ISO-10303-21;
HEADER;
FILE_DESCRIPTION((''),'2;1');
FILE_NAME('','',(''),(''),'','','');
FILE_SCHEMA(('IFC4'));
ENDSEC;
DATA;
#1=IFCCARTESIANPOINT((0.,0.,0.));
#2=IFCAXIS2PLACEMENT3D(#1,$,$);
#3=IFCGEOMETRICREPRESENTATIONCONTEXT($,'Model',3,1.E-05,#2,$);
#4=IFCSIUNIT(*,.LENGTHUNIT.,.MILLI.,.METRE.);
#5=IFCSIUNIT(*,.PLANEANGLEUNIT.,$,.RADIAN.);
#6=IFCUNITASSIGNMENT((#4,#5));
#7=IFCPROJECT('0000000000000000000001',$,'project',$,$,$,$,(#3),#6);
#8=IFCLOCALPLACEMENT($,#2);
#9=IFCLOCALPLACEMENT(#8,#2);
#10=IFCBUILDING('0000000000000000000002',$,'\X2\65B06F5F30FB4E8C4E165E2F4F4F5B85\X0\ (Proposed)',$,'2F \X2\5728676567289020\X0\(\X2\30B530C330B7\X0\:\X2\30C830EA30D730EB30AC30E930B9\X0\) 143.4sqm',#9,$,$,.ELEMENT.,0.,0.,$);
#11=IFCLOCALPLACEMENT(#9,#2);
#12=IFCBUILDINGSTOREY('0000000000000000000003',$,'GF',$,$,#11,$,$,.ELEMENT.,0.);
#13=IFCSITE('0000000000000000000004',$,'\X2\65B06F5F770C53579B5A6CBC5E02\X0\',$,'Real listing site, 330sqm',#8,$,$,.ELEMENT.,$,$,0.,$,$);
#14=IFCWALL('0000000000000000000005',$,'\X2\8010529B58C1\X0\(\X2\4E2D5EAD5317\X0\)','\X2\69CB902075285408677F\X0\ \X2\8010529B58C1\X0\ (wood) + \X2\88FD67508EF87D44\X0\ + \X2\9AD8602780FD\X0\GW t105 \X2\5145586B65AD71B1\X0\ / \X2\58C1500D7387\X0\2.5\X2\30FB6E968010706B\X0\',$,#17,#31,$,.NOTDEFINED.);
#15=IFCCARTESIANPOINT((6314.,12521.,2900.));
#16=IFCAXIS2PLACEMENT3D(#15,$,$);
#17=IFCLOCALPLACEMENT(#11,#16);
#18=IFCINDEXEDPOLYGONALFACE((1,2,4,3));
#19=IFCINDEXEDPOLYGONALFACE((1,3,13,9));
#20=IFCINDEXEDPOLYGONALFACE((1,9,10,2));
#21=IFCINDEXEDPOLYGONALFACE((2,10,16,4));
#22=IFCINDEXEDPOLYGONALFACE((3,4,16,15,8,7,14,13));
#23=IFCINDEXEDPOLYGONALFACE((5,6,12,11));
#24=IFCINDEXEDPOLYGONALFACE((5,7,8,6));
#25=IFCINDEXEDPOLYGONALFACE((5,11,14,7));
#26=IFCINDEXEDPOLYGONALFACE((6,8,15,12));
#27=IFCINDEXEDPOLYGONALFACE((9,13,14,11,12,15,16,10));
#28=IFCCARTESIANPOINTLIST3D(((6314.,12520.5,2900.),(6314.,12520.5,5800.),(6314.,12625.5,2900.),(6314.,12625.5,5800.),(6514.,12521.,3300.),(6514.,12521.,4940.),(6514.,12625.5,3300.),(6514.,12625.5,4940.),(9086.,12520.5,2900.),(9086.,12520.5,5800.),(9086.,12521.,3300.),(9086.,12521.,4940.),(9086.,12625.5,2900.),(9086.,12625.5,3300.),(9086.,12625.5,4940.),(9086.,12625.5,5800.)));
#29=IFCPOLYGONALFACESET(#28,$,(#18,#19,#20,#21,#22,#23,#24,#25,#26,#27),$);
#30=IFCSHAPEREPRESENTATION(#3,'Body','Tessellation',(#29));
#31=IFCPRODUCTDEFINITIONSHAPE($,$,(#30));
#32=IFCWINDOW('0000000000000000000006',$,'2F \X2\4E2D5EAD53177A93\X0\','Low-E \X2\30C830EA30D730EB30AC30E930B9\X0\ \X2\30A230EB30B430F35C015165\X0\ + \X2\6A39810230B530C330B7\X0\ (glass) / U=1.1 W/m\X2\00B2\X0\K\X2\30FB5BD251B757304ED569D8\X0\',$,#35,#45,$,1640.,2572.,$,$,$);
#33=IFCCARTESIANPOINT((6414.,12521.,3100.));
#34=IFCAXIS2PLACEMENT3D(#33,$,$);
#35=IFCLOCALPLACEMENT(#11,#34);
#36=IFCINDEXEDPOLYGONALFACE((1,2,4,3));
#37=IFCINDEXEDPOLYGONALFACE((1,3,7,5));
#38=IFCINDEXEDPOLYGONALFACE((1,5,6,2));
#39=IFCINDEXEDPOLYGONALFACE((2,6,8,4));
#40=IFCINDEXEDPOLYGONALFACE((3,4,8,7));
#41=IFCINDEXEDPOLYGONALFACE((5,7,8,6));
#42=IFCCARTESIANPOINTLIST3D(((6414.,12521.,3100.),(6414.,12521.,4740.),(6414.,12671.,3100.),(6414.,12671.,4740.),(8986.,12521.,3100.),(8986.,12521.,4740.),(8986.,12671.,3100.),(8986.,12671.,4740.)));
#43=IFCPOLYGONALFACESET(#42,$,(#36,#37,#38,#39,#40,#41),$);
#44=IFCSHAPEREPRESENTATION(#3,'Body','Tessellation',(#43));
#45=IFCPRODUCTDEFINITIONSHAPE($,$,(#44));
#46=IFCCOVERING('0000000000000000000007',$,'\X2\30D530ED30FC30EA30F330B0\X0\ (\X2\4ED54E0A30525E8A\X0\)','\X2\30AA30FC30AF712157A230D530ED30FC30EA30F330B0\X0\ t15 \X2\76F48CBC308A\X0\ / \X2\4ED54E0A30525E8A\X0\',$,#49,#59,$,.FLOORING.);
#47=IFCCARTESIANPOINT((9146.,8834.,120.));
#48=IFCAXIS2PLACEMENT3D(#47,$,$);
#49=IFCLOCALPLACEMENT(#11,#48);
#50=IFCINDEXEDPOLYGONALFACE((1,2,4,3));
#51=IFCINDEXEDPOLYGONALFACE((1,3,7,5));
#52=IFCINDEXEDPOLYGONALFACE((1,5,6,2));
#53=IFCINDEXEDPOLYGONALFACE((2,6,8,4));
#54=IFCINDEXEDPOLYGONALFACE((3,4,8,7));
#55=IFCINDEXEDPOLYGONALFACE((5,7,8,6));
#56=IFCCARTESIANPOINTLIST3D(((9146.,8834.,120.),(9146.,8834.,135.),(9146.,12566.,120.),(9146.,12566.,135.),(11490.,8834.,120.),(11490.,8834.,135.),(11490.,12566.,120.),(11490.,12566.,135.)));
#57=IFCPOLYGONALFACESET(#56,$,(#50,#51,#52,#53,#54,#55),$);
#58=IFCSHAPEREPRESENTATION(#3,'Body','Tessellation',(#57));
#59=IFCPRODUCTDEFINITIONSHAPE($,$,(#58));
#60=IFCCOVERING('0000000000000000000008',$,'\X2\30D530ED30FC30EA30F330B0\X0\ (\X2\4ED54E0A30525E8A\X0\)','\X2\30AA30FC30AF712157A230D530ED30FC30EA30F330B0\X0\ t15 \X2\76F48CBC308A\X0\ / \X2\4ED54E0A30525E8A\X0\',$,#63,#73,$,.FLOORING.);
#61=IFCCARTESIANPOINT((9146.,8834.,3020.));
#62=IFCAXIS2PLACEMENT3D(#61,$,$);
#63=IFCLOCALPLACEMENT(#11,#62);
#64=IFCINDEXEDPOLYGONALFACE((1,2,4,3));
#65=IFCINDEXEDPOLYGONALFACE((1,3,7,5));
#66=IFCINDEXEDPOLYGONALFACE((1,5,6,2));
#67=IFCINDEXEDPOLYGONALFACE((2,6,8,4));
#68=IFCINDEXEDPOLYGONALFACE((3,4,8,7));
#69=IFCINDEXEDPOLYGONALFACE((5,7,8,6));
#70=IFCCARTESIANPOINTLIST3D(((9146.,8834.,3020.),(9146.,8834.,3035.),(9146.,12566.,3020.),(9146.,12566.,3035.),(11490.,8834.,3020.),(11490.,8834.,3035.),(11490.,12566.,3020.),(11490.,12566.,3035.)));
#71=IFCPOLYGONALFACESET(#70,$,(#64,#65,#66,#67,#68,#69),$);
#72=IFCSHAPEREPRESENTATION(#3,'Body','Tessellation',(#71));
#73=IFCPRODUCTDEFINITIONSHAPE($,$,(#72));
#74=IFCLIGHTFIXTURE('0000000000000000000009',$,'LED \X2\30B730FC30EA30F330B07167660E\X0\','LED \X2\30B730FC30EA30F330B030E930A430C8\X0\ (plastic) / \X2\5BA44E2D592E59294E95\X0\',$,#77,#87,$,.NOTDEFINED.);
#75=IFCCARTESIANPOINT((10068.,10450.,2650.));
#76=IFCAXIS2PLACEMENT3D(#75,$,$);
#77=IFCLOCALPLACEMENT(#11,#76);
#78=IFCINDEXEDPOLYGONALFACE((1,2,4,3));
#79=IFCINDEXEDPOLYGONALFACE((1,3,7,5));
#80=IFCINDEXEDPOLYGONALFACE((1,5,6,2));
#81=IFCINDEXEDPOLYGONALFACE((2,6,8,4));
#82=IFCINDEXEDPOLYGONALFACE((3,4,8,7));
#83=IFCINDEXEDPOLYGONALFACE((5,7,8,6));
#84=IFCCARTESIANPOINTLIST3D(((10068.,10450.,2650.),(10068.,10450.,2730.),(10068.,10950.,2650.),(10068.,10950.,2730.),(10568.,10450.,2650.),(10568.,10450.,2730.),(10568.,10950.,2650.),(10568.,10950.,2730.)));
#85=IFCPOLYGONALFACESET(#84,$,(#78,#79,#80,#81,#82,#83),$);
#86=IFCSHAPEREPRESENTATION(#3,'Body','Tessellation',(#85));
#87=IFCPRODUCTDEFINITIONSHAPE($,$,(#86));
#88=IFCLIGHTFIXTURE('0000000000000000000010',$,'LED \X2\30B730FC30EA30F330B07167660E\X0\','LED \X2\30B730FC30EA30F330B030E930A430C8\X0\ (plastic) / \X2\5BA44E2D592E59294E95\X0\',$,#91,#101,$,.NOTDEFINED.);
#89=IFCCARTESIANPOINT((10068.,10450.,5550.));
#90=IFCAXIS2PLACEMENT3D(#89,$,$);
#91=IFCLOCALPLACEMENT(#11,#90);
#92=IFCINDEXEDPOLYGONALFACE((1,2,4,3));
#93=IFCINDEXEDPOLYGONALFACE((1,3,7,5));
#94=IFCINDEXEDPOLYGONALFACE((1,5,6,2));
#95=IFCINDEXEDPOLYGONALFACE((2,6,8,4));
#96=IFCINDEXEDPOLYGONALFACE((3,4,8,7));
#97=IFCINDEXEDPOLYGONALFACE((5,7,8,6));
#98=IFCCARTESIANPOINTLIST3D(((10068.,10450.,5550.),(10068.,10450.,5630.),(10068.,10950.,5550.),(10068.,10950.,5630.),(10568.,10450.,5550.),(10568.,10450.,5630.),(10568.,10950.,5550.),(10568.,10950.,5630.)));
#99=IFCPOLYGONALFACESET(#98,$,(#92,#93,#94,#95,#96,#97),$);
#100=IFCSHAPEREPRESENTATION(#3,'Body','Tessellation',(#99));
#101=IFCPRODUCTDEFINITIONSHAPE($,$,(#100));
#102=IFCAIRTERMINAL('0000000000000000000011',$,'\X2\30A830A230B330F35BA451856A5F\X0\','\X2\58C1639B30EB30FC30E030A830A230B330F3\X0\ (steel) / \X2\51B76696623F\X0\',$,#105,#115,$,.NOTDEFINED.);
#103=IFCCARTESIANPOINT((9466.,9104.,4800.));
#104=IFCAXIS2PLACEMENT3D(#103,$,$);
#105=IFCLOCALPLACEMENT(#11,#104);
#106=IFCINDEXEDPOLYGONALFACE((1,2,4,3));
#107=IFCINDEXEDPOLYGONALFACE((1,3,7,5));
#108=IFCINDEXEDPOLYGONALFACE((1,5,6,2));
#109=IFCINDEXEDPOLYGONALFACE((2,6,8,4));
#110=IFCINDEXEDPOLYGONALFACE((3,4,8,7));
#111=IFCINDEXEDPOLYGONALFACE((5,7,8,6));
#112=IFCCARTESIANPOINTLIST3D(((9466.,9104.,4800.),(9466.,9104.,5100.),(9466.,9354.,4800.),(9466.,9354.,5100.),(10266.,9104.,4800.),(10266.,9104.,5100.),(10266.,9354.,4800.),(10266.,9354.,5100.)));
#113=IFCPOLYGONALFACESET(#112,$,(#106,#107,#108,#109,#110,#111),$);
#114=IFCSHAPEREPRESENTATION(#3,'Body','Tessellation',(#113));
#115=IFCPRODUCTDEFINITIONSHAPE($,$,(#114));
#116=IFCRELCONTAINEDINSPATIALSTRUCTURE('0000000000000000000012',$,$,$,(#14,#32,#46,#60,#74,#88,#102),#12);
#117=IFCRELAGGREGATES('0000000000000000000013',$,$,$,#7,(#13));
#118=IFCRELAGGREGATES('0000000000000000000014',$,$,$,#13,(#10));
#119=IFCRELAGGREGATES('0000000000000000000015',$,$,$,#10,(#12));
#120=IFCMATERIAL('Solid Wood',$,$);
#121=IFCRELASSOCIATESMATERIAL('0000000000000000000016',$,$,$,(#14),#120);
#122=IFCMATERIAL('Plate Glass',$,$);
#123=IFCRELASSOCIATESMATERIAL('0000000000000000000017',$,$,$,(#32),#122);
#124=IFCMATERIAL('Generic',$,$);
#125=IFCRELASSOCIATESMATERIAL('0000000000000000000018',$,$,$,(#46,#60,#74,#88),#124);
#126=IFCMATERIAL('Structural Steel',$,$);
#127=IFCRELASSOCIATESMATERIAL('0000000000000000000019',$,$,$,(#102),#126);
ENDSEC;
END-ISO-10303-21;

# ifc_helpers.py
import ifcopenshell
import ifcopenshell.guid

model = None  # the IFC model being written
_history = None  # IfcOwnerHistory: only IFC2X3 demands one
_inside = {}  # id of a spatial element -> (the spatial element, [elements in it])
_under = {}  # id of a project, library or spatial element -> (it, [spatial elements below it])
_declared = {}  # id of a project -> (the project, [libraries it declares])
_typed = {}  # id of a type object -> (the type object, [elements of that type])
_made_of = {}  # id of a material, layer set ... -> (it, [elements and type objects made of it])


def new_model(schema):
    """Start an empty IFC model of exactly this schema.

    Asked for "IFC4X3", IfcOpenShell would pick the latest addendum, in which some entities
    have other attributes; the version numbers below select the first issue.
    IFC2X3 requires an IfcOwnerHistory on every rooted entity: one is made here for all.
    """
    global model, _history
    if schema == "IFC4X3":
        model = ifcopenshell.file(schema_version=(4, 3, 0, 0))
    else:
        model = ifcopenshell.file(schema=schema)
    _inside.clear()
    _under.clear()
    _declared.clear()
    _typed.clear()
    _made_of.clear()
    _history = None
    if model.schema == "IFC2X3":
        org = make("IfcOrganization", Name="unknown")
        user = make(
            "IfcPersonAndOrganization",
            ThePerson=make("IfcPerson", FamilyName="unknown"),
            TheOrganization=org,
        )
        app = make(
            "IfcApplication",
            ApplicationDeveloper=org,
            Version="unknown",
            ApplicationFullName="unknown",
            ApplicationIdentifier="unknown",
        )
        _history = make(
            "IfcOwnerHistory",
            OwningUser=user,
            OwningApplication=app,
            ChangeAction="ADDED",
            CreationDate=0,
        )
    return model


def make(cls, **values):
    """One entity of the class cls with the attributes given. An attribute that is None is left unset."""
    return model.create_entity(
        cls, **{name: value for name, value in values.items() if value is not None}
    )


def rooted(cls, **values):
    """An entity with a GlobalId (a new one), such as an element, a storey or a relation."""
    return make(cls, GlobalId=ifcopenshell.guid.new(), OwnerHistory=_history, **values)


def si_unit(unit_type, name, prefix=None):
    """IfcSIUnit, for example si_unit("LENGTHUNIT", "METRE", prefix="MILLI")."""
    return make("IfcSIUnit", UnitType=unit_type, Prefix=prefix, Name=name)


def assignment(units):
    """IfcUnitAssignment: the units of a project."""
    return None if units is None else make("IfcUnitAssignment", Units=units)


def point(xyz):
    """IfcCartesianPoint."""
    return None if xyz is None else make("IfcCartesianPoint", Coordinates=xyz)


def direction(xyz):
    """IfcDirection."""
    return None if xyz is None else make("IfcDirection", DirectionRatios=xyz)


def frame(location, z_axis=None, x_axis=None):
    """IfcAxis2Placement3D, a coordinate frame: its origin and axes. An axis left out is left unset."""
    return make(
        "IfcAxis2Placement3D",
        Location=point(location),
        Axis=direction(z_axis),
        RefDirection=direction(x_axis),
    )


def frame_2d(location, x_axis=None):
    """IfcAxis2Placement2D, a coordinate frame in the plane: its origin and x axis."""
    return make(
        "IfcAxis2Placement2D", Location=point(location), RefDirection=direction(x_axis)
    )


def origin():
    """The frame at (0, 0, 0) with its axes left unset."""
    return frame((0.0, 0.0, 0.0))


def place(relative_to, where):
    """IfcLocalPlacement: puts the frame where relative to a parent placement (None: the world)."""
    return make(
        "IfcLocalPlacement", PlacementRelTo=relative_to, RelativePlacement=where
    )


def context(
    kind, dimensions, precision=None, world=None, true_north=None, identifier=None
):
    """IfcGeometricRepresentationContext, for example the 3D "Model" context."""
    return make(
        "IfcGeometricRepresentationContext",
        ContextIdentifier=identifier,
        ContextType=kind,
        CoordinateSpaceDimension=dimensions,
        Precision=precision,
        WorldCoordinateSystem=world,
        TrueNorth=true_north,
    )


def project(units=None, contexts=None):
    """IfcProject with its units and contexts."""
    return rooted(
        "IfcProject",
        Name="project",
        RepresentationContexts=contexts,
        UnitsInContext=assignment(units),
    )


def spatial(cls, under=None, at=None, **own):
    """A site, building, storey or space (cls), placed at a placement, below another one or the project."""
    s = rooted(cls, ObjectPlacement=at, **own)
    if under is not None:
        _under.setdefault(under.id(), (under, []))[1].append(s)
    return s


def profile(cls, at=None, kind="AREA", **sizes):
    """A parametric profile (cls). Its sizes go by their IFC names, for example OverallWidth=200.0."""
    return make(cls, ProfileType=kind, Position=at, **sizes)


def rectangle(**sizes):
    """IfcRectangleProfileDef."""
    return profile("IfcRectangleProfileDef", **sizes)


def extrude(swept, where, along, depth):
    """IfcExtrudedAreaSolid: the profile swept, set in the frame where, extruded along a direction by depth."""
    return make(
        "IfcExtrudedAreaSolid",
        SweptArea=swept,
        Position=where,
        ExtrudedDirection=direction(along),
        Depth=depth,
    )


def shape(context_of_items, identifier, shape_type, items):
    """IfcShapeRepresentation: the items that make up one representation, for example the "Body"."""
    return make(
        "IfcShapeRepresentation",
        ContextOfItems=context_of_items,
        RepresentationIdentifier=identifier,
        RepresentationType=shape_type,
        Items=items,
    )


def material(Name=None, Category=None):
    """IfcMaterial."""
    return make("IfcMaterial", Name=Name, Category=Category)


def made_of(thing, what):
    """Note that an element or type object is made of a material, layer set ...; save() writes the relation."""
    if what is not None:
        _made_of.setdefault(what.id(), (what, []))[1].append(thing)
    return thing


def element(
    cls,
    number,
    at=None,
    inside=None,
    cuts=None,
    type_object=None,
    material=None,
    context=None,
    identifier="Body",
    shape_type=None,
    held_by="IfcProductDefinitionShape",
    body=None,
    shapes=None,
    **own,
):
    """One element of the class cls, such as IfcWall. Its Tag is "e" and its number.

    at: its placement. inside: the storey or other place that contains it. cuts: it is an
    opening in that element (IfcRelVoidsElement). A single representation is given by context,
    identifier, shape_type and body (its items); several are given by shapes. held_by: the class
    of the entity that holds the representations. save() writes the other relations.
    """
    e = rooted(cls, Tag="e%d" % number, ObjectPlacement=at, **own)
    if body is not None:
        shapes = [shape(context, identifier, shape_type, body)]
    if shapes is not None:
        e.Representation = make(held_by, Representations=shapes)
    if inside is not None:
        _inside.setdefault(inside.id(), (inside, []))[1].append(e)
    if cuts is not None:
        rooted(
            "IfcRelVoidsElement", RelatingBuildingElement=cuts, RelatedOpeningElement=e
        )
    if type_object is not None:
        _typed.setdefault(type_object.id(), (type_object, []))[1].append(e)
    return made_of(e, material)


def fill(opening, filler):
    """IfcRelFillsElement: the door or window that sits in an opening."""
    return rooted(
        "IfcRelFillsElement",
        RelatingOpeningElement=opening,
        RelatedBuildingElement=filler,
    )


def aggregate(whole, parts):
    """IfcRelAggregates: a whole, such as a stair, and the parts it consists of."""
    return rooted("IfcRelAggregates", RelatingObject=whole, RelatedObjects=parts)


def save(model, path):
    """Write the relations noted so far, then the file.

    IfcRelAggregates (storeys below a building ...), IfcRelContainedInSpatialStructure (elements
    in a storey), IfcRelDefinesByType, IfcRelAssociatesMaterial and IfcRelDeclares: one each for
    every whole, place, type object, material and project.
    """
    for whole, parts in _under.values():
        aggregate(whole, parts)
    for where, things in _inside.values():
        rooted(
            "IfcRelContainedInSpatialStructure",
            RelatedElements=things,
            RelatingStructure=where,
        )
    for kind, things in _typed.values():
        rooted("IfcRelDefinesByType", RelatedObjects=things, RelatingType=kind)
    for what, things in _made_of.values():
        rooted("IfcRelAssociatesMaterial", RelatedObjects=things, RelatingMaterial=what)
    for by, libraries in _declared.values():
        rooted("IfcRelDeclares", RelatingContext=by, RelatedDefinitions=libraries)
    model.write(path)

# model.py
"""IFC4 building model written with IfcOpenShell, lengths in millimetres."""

from ifc_helpers import new_model, si_unit, frame, frame_2d, origin, place, context, project, spatial, rectangle, extrude, material, element, fill, save


model = new_model("IFC4")

# Units and contexts
model_context = context("Model", 3, precision=1e-05, world=origin())
ifc_project = project(units=[si_unit("LENGTHUNIT", "METRE", prefix="MILLI"), si_unit("PLANEANGLEUNIT", "RADIAN")], contexts=[model_context])

# Site, building, storey
site_placement = place(None, origin())
site = spatial("IfcSite", under=ifc_project, at=site_placement, Name="新潟県南魚沼市", ObjectType="Real listing site, 330sqm", CompositionType="ELEMENT", RefElevation=0.0)
building_placement = place(site_placement, origin())
building = spatial("IfcBuilding", under=site, at=building_placement, Name="新潟・二世帯住宅 (Proposed)", ObjectType="2F 在来木造(サッシ:トリプルガラス) 143.4sqm", CompositionType="ELEMENT", ElevationOfRefHeight=0.0, ElevationOfTerrain=0.0)
storey_placement = place(building_placement, origin())
storey = spatial("IfcBuildingStorey", under=building, at=storey_placement, Name="GF", CompositionType="ELEMENT", Elevation=0.0)

# Shared definitions
ifc_material_1 = material(Name="Solid Wood")

# Wall, opening, window
ifc_material_2 = material(Name="Plate Glass")
wall_1_placement = place(storey_placement, frame((6314.0, 12521.0, 2900.0)))
wall_1 = element("IfcWall", 1, at=wall_1_placement, inside=storey, material=ifc_material_1, Name="耐力壁(中庭北)", Description="構造用合板 耐力壁 (wood) + 製材軸組 + 高性能GW t105 充填断熱 / 壁倍率2.5・準耐火", PredefinedType="NOTDEFINED", context=model_context, shape_type="SweptSolid", body=[
    extrude(rectangle(XDim=2772.0, YDim=105.0, at=frame_2d((1386.0, 52.0))), frame((6314.0, 12521.0, 2900.0)), (0.0, 0.0, 1.0), 2900.0),
])
opening_1_placement = place(storey_placement, frame((6414.0, 12521.0, 3100.0)))
opening_1 = element("IfcOpeningElement", 2, at=opening_1_placement, cuts=wall_1, PredefinedType="NOTDEFINED", context=model_context, shape_type="SweptSolid", body=[
    extrude(rectangle(XDim=2572.0, YDim=150.0, at=frame_2d((1286.0, 75.0))), frame((6414.0, 12521.0, 3100.0)), (0.0, 0.0, 1.0), 1640.0),
])
window_1_placement = place(storey_placement, frame((6414.0, 12521.0, 3100.0)))
window_1 = element("IfcWindow", 3, at=window_1_placement, inside=storey, material=ifc_material_2, Name="2F 中庭北窓", Description="Low-E トリプルガラス アルゴン封入 + 樹脂サッシ (glass) / U=1.1 W/m²K・寒冷地仕様", OverallHeight=1640.0, OverallWidth=2572.0, context=model_context, shape_type="SweptSolid", body=[
    extrude(rectangle(XDim=2572.0, YDim=150.0, at=frame_2d((1286.0, 75.0))), frame((6414.0, 12521.0, 3100.0)), (0.0, 0.0, 1.0), 1640.0),
])
fill(opening_1, window_1)

# Coverings
ifc_material_3 = material(Name="Generic")
covering_1_placement = place(storey_placement, frame((9146.0, 8834.0, 120.0)))
element("IfcCovering", 4, at=covering_1_placement, inside=storey, material=ifc_material_3, Name="フローリング (仕上げ床)", Description="オーク無垢フローリング t15 直貼り / 仕上げ床", PredefinedType="FLOORING", context=model_context, shape_type="SweptSolid", body=[
    extrude(rectangle(XDim=2344.0, YDim=3732.0, at=frame_2d((1172.0, 1866.0))), frame((9146.0, 8834.0, 120.0)), (0.0, 0.0, 1.0), 15.0),
])
covering_2_placement = place(storey_placement, frame((9146.0, 8834.0, 3020.0)))
element("IfcCovering", 5, at=covering_2_placement, inside=storey, material=ifc_material_3, Name="フローリング (仕上げ床)", Description="オーク無垢フローリング t15 直貼り / 仕上げ床", PredefinedType="FLOORING", context=model_context, shape_type="SweptSolid", body=[
    extrude(rectangle(XDim=2344.0, YDim=3732.0, at=frame_2d((1172.0, 1866.0))), frame((9146.0, 8834.0, 3020.0)), (0.0, 0.0, 1.0), 15.0),
])

# Light fixtures
light_fixture_1_placement = place(storey_placement, frame((10068.0, 10450.0, 2650.0)))
element("IfcLightFixture", 6, at=light_fixture_1_placement, inside=storey, material=ifc_material_3, Name="LED シーリング照明", Description="LED シーリングライト (plastic) / 室中央天井", PredefinedType="NOTDEFINED", context=model_context, shape_type="SweptSolid", body=[
    extrude(rectangle(XDim=500.0, YDim=500.0, at=frame_2d((250.0, 250.0))), frame((10068.0, 10450.0, 2650.0)), (0.0, 0.0, 1.0), 80.0),
])
light_fixture_2_placement = place(storey_placement, frame((10068.0, 10450.0, 5550.0)))
element("IfcLightFixture", 7, at=light_fixture_2_placement, inside=storey, material=ifc_material_3, Name="LED シーリング照明", Description="LED シーリングライト (plastic) / 室中央天井", PredefinedType="NOTDEFINED", context=model_context, shape_type="SweptSolid", body=[
    extrude(rectangle(XDim=500.0, YDim=500.0, at=frame_2d((250.0, 250.0))), frame((10068.0, 10450.0, 5550.0)), (0.0, 0.0, 1.0), 80.0),
])

# Air terminal
ifc_material_4 = material(Name="Structural Steel")
air_terminal_placement = place(storey_placement, frame((9466.0, 9104.0, 4800.0)))
element("IfcAirTerminal", 8, at=air_terminal_placement, inside=storey, material=ifc_material_4, Name="エアコン室内機", Description="壁掛ルームエアコン (steel) / 冷暖房", PredefinedType="NOTDEFINED", context=model_context, shape_type="SweptSolid", body=[
    extrude(rectangle(XDim=800.0, YDim=250.0, at=frame_2d((400.0, 125.0))), frame((9466.0, 9104.0, 4800.0)), (0.0, 0.0, 1.0), 300.0),
])

save(model, "model.ifc")
